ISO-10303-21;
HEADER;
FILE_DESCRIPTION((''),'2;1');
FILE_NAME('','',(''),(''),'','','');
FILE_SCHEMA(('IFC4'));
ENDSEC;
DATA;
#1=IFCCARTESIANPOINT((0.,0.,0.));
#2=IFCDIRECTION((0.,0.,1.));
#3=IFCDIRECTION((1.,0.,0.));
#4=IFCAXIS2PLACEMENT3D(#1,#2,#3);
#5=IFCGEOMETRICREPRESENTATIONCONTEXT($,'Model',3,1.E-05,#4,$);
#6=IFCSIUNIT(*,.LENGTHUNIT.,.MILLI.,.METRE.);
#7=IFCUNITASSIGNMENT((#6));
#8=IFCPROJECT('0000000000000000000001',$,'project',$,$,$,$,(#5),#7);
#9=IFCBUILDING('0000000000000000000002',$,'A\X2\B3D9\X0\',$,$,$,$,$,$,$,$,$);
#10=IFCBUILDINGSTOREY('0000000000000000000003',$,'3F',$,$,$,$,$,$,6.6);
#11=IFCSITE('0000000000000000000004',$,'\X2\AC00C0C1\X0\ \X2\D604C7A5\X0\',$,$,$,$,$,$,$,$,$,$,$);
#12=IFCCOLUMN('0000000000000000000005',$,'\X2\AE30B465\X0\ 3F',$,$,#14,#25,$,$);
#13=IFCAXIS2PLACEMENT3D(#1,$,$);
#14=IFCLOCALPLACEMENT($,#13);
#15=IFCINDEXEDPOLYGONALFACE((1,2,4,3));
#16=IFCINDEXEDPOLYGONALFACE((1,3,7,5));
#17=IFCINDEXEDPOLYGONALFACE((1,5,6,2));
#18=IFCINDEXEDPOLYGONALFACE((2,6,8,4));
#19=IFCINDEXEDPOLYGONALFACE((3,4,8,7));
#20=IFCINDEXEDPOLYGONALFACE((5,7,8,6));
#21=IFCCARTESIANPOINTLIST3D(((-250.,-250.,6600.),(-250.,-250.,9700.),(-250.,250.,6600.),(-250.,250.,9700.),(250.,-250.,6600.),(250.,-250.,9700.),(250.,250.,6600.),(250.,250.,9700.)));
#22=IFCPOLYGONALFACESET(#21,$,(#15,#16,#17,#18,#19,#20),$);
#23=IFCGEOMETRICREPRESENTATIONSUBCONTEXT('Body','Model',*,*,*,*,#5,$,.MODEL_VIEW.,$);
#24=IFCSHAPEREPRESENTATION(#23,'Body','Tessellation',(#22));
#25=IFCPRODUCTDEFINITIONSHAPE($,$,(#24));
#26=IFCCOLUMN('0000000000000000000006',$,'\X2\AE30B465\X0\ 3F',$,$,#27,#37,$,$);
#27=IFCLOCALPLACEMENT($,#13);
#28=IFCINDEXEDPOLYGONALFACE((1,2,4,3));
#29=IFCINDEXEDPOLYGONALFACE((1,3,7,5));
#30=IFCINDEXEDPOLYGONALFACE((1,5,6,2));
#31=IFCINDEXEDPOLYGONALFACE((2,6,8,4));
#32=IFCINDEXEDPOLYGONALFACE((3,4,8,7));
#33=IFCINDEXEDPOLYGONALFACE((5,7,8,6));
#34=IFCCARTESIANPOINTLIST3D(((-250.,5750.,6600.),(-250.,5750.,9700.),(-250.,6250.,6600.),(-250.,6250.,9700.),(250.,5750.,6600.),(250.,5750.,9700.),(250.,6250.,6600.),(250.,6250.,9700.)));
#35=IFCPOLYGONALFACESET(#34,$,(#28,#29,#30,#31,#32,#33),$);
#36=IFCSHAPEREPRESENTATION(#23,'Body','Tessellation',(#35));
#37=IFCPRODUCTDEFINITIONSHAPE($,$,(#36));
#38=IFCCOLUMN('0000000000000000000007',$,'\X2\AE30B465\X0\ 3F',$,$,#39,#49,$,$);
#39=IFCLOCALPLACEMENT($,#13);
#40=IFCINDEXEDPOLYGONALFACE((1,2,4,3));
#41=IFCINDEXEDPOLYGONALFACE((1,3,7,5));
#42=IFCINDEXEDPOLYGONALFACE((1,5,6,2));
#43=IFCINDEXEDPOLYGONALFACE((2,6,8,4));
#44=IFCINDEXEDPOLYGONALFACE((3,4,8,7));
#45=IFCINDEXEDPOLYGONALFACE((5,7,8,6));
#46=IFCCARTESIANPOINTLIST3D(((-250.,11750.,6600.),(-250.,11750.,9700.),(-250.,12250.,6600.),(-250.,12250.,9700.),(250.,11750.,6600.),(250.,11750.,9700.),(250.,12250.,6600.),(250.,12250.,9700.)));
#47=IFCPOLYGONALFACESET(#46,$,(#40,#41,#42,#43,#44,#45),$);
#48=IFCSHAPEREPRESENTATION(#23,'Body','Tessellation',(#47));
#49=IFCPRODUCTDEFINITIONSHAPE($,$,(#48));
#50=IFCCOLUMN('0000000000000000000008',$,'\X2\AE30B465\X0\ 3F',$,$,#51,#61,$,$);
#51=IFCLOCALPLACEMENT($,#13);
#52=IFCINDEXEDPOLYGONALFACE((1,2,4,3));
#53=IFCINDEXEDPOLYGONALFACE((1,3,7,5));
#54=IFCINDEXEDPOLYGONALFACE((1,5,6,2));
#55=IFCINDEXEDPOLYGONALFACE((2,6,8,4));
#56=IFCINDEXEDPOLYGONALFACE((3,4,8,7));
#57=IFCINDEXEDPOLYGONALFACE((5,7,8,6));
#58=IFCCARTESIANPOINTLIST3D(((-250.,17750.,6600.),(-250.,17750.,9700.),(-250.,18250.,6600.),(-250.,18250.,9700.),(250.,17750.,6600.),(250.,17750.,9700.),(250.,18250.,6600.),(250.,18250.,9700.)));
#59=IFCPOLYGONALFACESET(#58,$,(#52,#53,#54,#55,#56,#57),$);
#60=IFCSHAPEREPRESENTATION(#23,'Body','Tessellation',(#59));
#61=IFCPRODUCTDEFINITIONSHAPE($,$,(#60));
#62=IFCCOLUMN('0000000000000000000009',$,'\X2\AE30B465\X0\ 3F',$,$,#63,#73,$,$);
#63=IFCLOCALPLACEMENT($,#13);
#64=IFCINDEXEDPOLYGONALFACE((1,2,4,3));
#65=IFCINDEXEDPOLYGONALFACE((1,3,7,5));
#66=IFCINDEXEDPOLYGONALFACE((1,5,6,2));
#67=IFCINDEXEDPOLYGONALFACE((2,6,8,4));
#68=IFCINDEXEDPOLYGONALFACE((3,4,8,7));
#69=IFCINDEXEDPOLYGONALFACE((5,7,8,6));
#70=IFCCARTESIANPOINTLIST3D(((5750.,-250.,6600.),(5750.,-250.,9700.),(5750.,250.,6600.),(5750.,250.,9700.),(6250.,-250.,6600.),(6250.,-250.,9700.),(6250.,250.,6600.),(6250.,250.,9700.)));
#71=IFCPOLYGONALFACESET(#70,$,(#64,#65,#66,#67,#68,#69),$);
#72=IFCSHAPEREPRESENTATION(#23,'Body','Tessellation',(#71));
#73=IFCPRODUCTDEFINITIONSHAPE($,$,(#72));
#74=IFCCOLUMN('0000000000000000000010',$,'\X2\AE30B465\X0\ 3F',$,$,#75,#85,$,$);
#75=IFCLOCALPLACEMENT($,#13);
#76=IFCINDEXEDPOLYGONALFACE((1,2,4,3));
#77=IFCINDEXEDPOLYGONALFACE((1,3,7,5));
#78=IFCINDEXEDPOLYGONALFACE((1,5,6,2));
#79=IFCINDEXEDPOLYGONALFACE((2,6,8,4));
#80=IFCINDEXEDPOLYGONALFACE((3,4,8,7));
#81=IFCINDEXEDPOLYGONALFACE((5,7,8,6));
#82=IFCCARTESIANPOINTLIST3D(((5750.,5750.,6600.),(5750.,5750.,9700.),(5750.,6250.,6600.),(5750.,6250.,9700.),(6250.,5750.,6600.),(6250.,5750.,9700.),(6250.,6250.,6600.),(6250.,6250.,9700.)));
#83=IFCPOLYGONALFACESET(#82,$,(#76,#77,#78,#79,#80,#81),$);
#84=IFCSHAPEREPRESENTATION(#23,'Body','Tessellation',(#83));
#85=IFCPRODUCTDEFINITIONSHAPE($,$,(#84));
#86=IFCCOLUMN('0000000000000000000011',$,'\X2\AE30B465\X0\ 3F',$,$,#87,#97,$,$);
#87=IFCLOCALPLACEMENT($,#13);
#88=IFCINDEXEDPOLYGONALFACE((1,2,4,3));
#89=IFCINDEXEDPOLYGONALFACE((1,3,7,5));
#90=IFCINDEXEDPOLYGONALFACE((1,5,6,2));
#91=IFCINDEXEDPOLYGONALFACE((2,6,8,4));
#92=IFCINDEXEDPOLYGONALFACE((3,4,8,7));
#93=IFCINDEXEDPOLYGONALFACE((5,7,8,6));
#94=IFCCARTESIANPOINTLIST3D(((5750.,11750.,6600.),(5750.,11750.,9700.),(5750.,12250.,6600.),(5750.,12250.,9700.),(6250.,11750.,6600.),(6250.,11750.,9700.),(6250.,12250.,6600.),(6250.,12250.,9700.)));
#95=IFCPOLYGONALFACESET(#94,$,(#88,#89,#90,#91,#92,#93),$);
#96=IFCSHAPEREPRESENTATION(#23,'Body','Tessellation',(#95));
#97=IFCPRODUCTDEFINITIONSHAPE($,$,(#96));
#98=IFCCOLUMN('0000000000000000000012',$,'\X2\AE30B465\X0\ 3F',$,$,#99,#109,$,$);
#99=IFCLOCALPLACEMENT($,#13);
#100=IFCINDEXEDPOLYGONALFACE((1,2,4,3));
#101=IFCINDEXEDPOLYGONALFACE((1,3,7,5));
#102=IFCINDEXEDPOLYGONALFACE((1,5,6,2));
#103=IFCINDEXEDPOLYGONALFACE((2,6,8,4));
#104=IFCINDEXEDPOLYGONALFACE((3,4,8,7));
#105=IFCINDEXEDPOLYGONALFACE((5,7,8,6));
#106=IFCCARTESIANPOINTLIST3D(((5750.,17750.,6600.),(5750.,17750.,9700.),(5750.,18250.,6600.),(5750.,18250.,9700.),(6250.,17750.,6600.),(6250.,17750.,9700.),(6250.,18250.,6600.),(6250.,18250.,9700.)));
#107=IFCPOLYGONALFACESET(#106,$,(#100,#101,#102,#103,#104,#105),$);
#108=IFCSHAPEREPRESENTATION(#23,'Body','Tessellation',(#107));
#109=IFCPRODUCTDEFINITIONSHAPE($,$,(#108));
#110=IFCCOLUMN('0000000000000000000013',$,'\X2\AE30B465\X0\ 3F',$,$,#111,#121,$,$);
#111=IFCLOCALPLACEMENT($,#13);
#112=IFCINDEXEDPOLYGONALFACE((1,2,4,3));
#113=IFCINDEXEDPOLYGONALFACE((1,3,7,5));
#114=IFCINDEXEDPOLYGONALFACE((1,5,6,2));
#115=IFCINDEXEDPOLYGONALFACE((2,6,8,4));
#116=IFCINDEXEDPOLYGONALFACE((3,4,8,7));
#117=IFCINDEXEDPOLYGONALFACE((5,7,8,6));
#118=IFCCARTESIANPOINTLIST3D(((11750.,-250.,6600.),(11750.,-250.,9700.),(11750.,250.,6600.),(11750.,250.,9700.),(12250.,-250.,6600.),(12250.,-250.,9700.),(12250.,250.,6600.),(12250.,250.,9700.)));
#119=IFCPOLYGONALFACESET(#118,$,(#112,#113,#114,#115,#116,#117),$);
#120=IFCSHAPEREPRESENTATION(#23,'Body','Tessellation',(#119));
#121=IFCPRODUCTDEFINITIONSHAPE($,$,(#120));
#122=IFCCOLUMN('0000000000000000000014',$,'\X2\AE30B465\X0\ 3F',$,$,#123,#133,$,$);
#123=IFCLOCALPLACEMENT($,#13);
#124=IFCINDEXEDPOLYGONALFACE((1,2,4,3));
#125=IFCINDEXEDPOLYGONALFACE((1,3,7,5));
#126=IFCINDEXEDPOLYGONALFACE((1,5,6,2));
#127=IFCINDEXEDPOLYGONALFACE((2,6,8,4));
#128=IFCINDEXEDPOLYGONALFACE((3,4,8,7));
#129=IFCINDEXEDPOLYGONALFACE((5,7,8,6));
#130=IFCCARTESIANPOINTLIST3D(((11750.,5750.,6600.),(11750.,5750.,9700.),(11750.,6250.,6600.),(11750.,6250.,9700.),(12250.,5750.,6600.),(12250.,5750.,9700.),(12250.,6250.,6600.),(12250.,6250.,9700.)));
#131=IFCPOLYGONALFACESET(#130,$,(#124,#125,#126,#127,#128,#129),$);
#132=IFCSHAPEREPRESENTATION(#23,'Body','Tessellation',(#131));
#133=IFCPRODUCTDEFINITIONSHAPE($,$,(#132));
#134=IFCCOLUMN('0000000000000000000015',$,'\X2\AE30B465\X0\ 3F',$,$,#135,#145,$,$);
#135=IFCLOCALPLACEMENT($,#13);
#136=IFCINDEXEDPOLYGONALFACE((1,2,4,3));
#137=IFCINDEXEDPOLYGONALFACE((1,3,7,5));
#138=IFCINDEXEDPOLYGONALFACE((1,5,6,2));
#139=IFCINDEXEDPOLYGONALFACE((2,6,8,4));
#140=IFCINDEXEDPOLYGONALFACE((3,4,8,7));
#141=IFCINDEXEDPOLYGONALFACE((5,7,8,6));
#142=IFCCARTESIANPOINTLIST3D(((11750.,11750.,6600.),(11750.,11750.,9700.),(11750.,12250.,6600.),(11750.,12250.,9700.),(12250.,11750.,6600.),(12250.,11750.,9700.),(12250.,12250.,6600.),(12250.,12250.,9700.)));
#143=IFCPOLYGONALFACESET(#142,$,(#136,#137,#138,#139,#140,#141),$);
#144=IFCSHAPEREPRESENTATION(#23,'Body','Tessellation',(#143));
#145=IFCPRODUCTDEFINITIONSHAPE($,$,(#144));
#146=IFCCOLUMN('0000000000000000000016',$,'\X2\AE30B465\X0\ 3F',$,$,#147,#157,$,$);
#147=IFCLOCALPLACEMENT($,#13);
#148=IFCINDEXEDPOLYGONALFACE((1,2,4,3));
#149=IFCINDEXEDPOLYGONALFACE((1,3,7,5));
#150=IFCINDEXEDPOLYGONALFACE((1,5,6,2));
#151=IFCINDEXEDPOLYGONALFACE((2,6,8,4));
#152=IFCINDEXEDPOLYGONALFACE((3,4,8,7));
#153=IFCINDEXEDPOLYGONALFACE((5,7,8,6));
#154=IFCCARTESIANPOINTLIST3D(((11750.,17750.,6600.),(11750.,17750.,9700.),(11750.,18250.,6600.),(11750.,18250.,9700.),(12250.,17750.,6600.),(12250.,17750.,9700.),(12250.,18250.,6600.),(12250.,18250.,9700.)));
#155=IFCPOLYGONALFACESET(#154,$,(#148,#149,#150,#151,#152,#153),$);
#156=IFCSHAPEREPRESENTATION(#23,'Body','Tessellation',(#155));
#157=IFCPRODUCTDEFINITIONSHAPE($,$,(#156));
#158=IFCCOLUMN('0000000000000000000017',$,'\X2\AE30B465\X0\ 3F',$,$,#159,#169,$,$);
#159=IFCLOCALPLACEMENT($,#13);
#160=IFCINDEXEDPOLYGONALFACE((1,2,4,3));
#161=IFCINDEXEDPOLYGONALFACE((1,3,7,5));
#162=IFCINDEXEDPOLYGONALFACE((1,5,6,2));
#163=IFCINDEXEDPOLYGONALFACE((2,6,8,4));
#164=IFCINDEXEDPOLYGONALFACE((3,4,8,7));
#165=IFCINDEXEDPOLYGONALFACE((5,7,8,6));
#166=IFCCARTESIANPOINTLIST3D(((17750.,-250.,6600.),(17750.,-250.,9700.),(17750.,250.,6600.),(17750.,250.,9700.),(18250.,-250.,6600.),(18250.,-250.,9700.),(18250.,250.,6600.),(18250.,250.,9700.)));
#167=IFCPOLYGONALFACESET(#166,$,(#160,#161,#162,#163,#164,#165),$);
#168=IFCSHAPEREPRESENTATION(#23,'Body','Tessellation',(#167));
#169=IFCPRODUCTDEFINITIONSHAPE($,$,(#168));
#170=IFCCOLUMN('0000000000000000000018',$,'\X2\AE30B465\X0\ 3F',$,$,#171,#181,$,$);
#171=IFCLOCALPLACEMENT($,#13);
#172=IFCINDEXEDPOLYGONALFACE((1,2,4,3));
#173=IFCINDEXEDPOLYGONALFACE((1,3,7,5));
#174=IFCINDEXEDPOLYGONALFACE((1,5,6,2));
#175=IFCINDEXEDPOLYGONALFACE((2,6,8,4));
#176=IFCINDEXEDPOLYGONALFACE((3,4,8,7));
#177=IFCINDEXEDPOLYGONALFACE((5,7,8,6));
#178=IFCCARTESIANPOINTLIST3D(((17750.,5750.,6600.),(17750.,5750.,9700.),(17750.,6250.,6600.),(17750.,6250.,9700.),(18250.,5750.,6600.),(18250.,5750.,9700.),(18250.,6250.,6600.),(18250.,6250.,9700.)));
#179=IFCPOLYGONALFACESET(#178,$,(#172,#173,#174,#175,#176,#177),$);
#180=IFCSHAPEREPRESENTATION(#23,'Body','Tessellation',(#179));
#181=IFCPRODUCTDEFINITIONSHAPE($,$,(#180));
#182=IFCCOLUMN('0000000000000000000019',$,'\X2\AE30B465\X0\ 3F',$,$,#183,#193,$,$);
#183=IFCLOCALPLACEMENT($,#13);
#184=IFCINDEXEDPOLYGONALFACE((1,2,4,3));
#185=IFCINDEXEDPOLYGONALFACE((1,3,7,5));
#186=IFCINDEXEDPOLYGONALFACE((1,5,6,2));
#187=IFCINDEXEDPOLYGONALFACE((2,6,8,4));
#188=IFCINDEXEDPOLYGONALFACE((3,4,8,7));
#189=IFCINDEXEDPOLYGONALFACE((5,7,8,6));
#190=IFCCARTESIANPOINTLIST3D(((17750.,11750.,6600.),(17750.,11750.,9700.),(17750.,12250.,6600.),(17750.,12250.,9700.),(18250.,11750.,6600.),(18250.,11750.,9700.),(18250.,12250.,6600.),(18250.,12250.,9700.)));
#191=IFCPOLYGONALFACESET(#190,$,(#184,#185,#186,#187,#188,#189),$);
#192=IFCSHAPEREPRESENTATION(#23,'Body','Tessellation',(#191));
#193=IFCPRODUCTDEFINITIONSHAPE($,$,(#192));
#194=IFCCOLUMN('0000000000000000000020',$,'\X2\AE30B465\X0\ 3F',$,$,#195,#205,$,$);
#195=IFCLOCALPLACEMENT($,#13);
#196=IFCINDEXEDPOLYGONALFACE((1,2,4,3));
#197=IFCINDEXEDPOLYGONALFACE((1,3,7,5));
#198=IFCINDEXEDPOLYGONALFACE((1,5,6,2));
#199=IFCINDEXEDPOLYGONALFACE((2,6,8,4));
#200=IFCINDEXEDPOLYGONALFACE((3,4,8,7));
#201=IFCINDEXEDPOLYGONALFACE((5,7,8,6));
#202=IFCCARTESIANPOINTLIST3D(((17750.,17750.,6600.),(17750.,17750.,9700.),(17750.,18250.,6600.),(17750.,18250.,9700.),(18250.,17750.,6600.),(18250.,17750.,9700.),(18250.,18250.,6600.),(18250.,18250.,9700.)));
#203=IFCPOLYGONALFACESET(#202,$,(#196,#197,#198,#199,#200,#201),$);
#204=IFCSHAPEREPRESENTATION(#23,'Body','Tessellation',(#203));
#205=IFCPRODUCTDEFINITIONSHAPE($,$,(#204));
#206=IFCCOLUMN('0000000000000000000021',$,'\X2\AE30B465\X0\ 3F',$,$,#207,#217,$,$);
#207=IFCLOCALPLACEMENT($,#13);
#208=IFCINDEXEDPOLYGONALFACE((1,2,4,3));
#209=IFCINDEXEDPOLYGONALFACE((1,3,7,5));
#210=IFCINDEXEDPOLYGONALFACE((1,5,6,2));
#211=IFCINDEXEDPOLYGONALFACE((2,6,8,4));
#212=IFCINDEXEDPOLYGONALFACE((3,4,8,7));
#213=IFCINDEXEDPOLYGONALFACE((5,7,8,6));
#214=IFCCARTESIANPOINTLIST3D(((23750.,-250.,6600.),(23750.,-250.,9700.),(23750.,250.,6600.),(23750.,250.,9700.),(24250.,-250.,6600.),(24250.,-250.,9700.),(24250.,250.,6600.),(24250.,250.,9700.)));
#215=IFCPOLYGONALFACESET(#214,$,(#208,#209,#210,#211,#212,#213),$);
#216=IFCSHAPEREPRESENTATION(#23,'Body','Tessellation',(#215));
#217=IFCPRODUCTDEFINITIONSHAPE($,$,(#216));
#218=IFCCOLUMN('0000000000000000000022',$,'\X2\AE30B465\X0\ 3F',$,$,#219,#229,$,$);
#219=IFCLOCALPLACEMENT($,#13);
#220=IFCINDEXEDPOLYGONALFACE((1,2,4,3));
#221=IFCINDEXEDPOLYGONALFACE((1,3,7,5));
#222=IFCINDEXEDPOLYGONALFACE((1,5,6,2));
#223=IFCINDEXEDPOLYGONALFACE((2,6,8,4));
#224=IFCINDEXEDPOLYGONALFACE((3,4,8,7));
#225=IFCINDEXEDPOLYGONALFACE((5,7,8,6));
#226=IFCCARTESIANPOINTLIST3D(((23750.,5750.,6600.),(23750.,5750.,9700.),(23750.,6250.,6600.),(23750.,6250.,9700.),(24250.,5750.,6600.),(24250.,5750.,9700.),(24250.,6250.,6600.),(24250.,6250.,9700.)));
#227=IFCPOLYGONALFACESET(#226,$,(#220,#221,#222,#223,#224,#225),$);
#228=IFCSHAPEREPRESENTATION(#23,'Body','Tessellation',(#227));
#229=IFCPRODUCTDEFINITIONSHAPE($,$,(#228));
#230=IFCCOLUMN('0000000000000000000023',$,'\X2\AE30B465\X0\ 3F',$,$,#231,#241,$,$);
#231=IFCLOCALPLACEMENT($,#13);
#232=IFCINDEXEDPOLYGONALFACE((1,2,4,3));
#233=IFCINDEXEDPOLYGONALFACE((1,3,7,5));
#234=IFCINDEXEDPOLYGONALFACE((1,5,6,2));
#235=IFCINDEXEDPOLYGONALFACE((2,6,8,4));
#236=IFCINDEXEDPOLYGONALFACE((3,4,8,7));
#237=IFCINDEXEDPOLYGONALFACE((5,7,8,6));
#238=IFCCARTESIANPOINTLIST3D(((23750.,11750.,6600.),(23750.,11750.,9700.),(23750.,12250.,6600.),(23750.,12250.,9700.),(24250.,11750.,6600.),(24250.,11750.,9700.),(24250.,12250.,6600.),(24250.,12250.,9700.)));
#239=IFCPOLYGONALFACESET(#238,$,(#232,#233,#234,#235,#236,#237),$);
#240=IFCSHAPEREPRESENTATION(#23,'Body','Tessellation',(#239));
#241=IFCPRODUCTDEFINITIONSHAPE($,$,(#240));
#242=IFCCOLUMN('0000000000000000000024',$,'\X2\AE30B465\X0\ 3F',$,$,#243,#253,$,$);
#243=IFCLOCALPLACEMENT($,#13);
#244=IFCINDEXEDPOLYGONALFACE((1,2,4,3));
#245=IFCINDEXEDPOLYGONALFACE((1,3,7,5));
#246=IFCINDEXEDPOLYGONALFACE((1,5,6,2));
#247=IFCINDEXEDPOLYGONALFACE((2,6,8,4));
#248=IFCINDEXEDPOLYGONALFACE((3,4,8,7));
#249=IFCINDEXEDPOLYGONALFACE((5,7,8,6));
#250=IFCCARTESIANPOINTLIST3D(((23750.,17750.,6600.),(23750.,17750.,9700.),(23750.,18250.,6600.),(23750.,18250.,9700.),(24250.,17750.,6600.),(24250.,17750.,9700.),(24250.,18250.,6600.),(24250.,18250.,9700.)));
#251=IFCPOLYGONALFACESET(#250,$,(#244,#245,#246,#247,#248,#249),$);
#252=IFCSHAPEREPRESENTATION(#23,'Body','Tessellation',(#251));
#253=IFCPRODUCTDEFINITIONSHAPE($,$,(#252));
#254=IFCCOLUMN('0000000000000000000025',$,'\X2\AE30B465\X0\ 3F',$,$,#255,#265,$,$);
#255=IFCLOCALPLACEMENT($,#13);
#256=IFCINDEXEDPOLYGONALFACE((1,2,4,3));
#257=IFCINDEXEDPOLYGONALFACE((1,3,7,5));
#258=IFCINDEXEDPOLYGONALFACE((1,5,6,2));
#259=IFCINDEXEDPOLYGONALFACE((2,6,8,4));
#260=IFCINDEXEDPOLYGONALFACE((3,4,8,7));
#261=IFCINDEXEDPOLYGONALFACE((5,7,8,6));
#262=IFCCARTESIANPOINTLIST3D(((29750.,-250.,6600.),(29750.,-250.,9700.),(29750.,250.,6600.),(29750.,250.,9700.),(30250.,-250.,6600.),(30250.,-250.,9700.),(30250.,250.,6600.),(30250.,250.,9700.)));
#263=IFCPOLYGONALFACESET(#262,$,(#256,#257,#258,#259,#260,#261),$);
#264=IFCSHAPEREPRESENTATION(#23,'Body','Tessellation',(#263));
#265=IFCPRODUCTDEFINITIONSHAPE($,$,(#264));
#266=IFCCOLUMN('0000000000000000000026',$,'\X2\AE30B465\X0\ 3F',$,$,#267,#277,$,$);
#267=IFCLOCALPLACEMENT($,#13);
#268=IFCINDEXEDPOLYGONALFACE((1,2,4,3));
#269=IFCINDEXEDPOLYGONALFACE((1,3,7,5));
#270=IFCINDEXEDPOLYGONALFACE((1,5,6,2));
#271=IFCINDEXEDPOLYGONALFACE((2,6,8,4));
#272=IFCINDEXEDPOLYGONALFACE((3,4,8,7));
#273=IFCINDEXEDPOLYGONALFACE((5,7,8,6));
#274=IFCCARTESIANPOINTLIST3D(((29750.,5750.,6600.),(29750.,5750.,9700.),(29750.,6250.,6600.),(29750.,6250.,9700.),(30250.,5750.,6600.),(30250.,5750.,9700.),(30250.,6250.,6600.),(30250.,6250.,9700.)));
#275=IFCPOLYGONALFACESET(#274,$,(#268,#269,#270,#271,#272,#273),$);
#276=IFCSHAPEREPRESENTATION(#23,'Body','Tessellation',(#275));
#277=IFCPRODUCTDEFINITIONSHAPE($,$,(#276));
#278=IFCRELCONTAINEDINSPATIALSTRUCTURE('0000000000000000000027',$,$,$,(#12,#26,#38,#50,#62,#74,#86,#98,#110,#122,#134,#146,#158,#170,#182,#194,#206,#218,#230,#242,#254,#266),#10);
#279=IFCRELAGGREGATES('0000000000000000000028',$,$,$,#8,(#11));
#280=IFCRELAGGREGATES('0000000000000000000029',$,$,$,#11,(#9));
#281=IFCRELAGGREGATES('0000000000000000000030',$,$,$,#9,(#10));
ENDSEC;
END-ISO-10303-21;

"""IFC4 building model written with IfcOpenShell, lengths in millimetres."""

from ifc_helpers import new_model, si_unit, frame, origin_with_axes, place, context, subcontext, project, spatial, indexed_curve, outline, extrude, element, save


model = new_model("IFC4")

# Units and contexts
model_context = context("Model", 3, precision=1e-05, world=origin_with_axes())
body_context = subcontext(model_context, "Body", "Model", "MODEL_VIEW")
ifc_project = project(units=[si_unit("LENGTHUNIT", "METRE", prefix="MILLI")], contexts=[model_context])

# Site, building, storey
site = spatial("IfcSite", under=ifc_project, Name="가상 현장")
building = spatial("IfcBuilding", under=site, Name="A동")
storey = spatial("IfcBuildingStorey", under=building, Name="3F", Elevation=6.6)

# Columns
for number, where, z_axis, x_axis, name in (
    (1, (-250.0, -250.0, 6600.0), (0.0, 0.0, 1.0), (1.0, 0.0, 0.0), "기둥 3F"),
    (2, (-250.0, 5750.0, 6600.0), (0.0, 0.0, 1.0), (1.0, 0.0, 0.0), "기둥 3F"),
    (3, (-250.0, 11750.0, 6600.0), (0.0, 0.0, 1.0), (1.0, 0.0, 0.0), "기둥 3F"),
    (4, (-250.0, 17750.0, 6600.0), (0.0, 0.0, 1.0), (1.0, 0.0, 0.0), "기둥 3F"),
    (5, (5750.0, -250.0, 6600.0), (0.0, 0.0, 1.0), (1.0, 0.0, 0.0), "기둥 3F"),
    (6, (5750.0, 5750.0, 6600.0), (0.0, 0.0, 1.0), (1.0, 0.0, 0.0), "기둥 3F"),
    (7, (5750.0, 11750.0, 6600.0), (0.0, 0.0, 1.0), (1.0, 0.0, 0.0), "기둥 3F"),
    (8, (5750.0, 17750.0, 6600.0), (0.0, 0.0, 1.0), (1.0, 0.0, 0.0), "기둥 3F"),
    (9, (11750.0, -250.0, 6600.0), (0.0, 0.0, 1.0), (1.0, 0.0, 0.0), "기둥 3F"),
    (10, (11750.0, 5750.0, 6600.0), (0.0, 0.0, 1.0), (1.0, 0.0, 0.0), "기둥 3F"),
    (11, (11750.0, 11750.0, 6600.0), (0.0, 0.0, 1.0), (1.0, 0.0, 0.0), "기둥 3F"),
    (12, (11750.0, 17750.0, 6600.0), (0.0, 0.0, 1.0), (1.0, 0.0, 0.0), "기둥 3F"),
    (13, (17750.0, -250.0, 6600.0), (0.0, 0.0, 1.0), (1.0, 0.0, 0.0), "기둥 3F"),
    (14, (17750.0, 5750.0, 6600.0), (0.0, 0.0, 1.0), (1.0, 0.0, 0.0), "기둥 3F"),
    (15, (17750.0, 11750.0, 6600.0), (0.0, 0.0, 1.0), (1.0, 0.0, 0.0), "기둥 3F"),
    (16, (17750.0, 17750.0, 6600.0), (0.0, 0.0, 1.0), (1.0, 0.0, 0.0), "기둥 3F"),
    (17, (23750.0, -250.0, 6600.0), (0.0, 0.0, 1.0), (1.0, 0.0, 0.0), "기둥 3F"),
    (18, (23750.0, 5750.0, 6600.0), (0.0, 0.0, 1.0), (1.0, 0.0, 0.0), "기둥 3F"),
    (19, (23750.0, 11750.0, 6600.0), (0.0, 0.0, 1.0), (1.0, 0.0, 0.0), "기둥 3F"),
    (20, (23750.0, 17750.0, 6600.0), (0.0, 0.0, 1.0), (1.0, 0.0, 0.0), "기둥 3F"),
    (21, (29750.0, -250.0, 6600.0), (0.0, 0.0, 1.0), (1.0, 0.0, 0.0), "기둥 3F"),
    (22, (29750.0, 5750.0, 6600.0), (0.0, 0.0, 1.0), (1.0, 0.0, 0.0), "기둥 3F"),
):
    element("IfcColumn", number, at=place(None, frame(where, z_axis=z_axis, x_axis=x_axis)), inside=storey, Name=name, context=body_context, shape_type="SweptSolid", body=[
        extrude(outline(indexed_curve([(0.0, 0.0), (0.0, 500.0), (500.0, 500.0), (500.0, 0.0), (0.0, 0.0)], self_intersect=False)), origin_with_axes(), (0.0, 0.0, 1.0), 3100.0),
    ])

save(model, "model.ifc")
